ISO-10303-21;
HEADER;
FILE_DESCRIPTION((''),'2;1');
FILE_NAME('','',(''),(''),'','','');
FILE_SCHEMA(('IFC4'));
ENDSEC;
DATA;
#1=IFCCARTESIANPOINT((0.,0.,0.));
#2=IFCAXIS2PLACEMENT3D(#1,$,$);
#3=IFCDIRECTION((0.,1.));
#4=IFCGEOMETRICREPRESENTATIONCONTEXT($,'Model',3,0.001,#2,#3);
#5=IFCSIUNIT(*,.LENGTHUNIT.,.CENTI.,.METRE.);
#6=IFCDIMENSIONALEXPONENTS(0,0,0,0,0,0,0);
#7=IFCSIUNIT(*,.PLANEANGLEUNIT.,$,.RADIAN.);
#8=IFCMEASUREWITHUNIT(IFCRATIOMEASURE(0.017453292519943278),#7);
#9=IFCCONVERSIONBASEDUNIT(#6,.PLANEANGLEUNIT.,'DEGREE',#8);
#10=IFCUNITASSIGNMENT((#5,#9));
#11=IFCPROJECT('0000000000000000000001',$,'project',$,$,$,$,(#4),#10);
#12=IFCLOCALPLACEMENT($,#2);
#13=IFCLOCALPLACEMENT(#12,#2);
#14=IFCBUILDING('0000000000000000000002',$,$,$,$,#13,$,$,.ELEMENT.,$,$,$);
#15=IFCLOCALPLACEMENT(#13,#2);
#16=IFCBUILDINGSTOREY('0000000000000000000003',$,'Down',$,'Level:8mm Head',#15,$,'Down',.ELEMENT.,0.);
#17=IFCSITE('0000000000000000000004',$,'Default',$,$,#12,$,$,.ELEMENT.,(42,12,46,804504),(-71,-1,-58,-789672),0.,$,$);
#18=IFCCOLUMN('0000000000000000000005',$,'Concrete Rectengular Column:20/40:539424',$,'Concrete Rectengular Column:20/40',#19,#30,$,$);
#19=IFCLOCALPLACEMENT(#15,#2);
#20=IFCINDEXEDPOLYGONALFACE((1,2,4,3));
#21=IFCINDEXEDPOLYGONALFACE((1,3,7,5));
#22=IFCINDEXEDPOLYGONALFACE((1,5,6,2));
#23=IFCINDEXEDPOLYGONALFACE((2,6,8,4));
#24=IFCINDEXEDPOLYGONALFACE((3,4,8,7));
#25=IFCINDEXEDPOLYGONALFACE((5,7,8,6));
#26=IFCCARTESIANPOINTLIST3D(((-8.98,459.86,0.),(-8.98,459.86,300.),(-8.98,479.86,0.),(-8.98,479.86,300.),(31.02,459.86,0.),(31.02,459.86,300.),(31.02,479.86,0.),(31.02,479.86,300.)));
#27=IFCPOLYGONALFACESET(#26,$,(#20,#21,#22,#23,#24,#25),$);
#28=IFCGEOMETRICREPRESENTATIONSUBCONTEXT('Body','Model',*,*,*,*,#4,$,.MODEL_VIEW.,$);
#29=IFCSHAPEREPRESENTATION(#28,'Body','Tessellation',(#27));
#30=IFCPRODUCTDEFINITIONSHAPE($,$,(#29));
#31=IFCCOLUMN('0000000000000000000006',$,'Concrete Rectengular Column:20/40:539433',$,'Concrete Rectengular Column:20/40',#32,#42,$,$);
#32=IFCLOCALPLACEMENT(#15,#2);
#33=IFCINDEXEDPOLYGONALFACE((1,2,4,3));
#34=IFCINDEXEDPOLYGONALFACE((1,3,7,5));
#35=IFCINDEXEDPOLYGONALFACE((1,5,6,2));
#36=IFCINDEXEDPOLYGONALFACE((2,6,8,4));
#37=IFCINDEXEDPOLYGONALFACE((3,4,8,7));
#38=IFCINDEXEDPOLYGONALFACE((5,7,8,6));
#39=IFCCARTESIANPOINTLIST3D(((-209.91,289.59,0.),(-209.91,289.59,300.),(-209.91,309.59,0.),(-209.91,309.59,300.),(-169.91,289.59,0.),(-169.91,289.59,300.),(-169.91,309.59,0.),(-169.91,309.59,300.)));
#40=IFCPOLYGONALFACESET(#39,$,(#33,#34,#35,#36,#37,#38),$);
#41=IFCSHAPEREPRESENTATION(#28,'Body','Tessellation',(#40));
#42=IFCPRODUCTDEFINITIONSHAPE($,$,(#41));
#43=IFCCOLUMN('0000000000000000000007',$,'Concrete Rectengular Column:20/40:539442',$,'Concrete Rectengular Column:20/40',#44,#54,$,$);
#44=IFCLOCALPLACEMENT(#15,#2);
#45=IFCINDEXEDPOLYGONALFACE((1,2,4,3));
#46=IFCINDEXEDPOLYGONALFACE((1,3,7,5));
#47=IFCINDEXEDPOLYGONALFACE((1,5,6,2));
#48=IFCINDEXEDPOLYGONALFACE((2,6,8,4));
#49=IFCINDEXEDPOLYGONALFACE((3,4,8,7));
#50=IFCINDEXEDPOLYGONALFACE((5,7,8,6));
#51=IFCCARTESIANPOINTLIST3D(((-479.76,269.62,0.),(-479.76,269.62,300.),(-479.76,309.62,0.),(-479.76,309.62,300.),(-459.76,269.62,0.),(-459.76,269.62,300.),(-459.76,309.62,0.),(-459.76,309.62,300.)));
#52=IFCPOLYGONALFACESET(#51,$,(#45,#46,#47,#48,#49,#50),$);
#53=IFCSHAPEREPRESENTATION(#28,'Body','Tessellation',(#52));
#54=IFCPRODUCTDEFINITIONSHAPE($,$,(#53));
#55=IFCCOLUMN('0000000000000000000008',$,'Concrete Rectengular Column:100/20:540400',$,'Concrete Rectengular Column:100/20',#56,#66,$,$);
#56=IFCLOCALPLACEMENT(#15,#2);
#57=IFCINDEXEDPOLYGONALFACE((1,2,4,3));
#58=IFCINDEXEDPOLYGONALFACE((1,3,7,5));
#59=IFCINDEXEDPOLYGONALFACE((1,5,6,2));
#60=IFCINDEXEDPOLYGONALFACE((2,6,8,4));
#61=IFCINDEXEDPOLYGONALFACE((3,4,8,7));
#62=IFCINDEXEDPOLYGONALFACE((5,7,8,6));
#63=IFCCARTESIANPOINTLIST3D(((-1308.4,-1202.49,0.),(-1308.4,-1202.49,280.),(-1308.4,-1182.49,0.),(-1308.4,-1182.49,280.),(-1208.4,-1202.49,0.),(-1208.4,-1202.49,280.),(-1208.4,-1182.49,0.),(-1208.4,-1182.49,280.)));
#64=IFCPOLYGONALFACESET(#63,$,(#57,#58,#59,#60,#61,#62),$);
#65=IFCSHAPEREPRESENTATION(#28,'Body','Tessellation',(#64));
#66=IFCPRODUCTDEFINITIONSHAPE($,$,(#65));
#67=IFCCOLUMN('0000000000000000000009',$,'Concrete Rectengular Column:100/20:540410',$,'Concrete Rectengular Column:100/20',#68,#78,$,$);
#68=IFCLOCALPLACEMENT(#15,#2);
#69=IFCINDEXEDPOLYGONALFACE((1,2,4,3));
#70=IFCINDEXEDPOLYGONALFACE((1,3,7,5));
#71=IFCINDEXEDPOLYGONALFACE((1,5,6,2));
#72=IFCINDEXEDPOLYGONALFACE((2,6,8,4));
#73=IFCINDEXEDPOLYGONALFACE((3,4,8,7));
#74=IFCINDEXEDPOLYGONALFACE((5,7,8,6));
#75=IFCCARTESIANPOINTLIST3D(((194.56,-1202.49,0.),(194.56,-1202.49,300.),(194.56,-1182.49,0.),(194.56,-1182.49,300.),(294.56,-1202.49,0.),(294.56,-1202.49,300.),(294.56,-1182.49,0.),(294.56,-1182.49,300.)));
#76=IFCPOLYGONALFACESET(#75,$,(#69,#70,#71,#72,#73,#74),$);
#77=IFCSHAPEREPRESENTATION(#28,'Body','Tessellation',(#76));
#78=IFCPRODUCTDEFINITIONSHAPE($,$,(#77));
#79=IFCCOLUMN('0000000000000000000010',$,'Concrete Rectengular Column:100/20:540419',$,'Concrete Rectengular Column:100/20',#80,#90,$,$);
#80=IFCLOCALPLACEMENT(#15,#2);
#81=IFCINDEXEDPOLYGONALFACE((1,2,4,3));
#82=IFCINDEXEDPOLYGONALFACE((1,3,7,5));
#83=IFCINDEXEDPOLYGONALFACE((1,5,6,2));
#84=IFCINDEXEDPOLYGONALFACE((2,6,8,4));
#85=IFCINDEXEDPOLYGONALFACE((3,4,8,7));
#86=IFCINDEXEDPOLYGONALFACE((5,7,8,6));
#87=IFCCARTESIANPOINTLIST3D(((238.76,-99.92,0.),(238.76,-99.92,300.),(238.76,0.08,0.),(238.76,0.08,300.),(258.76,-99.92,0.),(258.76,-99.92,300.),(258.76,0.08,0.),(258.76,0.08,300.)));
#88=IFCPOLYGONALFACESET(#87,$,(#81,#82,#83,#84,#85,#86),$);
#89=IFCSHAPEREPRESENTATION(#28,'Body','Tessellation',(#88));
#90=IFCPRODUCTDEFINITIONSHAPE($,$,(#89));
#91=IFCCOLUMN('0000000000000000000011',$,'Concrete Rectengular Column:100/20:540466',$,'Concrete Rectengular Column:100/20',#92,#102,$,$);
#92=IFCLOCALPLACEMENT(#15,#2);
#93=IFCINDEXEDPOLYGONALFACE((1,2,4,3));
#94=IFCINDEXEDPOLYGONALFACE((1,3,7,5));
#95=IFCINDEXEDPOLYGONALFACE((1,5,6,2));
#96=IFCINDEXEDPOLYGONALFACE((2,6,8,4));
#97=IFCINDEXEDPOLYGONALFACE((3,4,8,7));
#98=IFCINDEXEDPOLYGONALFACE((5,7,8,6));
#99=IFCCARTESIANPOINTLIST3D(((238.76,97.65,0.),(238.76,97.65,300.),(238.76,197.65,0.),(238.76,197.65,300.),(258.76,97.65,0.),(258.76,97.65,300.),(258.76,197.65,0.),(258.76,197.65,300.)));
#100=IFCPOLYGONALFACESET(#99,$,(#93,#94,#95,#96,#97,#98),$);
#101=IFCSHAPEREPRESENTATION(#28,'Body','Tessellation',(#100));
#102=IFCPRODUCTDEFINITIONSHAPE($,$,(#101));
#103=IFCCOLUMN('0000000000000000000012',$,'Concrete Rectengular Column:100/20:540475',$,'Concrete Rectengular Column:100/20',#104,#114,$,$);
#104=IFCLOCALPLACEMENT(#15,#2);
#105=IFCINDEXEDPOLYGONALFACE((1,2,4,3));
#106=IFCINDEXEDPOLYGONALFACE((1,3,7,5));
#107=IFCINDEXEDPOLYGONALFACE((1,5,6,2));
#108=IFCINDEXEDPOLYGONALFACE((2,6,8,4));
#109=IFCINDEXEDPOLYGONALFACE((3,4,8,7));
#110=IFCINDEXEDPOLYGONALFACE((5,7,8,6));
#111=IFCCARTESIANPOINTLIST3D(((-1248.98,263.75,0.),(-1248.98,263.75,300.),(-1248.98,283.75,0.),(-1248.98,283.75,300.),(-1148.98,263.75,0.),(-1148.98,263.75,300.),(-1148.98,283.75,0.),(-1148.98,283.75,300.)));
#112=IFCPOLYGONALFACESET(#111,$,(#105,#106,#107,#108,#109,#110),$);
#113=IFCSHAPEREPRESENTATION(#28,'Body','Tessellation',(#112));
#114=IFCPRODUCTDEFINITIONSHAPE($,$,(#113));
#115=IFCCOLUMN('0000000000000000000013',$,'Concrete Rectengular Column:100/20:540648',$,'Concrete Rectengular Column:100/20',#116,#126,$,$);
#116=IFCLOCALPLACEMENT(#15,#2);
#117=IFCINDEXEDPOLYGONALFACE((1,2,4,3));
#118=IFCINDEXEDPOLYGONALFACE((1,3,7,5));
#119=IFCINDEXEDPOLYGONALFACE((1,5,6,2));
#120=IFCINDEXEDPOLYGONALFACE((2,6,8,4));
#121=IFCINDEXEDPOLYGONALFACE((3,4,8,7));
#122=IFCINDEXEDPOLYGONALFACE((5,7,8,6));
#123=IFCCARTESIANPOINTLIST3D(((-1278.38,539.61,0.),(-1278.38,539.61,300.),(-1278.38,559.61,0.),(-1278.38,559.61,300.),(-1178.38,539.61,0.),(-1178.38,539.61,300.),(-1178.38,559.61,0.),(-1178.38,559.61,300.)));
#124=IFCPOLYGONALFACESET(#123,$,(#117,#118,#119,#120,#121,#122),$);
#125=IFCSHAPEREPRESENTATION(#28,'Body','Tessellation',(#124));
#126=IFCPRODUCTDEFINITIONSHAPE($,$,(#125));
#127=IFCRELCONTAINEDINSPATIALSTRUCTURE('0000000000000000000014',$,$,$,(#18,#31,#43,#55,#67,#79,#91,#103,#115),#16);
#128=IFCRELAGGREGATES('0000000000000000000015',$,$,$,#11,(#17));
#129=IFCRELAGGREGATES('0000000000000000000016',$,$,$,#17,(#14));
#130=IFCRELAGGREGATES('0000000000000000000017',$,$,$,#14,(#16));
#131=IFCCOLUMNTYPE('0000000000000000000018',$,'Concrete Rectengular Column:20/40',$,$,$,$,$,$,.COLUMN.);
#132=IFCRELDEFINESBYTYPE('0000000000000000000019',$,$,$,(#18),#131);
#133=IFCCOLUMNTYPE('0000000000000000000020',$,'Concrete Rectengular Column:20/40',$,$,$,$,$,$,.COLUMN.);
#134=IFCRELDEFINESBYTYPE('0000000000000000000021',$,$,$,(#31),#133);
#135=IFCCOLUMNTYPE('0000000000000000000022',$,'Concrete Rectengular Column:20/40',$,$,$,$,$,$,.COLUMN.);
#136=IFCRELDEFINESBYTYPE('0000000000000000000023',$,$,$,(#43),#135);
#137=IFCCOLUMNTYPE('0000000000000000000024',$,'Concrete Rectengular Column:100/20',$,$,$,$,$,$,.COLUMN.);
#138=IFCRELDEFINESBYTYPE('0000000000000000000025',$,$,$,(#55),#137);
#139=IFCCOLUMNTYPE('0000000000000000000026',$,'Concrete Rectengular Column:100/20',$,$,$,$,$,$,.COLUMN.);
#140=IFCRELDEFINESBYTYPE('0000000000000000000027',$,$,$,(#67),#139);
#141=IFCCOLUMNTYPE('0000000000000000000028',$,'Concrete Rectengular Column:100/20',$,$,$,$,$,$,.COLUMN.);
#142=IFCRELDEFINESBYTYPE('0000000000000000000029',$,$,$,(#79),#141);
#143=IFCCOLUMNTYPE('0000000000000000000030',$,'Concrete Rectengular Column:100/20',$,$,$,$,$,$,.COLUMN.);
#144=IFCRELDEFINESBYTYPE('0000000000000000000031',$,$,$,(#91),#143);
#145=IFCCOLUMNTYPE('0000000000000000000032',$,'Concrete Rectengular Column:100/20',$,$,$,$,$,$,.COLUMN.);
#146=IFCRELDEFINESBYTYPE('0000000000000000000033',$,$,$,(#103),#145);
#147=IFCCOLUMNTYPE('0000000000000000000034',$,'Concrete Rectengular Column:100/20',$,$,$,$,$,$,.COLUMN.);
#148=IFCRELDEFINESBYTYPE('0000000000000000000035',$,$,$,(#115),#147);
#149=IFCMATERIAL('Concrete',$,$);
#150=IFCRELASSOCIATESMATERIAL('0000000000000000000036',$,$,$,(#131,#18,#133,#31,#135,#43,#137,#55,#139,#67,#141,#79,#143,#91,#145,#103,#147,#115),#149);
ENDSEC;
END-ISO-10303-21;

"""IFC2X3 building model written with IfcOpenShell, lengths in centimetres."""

from ifc_helpers import new_model, entity, si_unit, converted_unit, direction, frame, frame_2d, origin, origin_2d_with_axis, place, context, subcontext, project, spatial, rectangle, extrude, source, transform, mapped, material, type_object, type_shapes, element, save


model = new_model("IFC2X3")

# Units and contexts
model_context = context("Model", 3, precision=0.001, world=origin(), true_north=direction((0.0, 1.0)))
body_context = subcontext(model_context, "Body", "Model", "MODEL_VIEW")
ifc_project = project(units=[si_unit("LENGTHUNIT", "METRE", prefix="CENTI"), converted_unit("PLANEANGLEUNIT", "DEGREE", entity("IfcRatioMeasure", 0.017453292519943278), si_unit("PLANEANGLEUNIT", "RADIAN"), dimensions=[0, 0, 0, 0, 0, 0, 0])], contexts=[model_context])

# Site, building, storey
site_placement = place(None, origin())
site = spatial("IfcSite", under=ifc_project, at=site_placement, Name="Default", CompositionType="ELEMENT", RefLatitude=(42, 12, 46, 804504), RefLongitude=(-71, -1, -58, -789672), RefElevation=0.0)
building_placement = place(site_placement, origin())
building = spatial("IfcBuilding", under=site, at=building_placement, CompositionType="ELEMENT")
storey_placement = place(building_placement, origin())
storey = spatial("IfcBuildingStorey", under=building, at=storey_placement, Name="Down", ObjectType="Level:8mm Head", LongName="Down", CompositionType="ELEMENT", Elevation=0.0)

# Columns
ifc_material = material(Name="Concrete")
column_type_1 = type_object("IfcColumnType", Name="Concrete Rectengular Column:20/40", PredefinedType="COLUMN", material=ifc_material)
shared_shape_1 = source(origin(), body_context, "Body", "SweptSolid", [
    extrude(rectangle(XDim=20.0, YDim=40.0, at=origin_2d_with_axis()), frame((11.02, 469.86, 0.0), z_axis=(0.0, 0.0, 1.0), x_axis=(0.0, -1.0, 0.0)), (0.0, 0.0, 1.0), 300.0),
])
type_shapes(column_type_1, [shared_shape_1])
column_1_placement = place(storey_placement, origin())
element("IfcColumn", 1, at=column_1_placement, inside=storey, type_object=column_type_1, material=ifc_material, Name="Concrete Rectengular Column:20/40:539424", ObjectType="Concrete Rectengular Column:20/40", context=body_context, shape_type="MappedRepresentation", body=[
    mapped(shared_shape_1, transform((0.0, 0.0, 0.0), scale=1.0)),
])
column_type_2 = type_object("IfcColumnType", Name="Concrete Rectengular Column:20/40", PredefinedType="COLUMN", material=ifc_material)
shared_shape_2 = source(origin(), body_context, "Body", "SweptSolid", [
    extrude(rectangle(XDim=20.0, YDim=40.0, at=origin_2d_with_axis()), frame((-189.91, 299.59, 0.0), z_axis=(0.0, 0.0, 1.0), x_axis=(0.0, -1.0, 0.0)), (0.0, 0.0, 1.0), 300.0),
])
type_shapes(column_type_2, [shared_shape_2])
column_2_placement = place(storey_placement, origin())
element("IfcColumn", 2, at=column_2_placement, inside=storey, type_object=column_type_2, material=ifc_material, Name="Concrete Rectengular Column:20/40:539433", ObjectType="Concrete Rectengular Column:20/40", context=body_context, shape_type="MappedRepresentation", body=[
    mapped(shared_shape_2, transform((0.0, 0.0, 0.0), scale=1.0)),
])
column_type_3 = type_object("IfcColumnType", Name="Concrete Rectengular Column:20/40", PredefinedType="COLUMN", material=ifc_material)
shared_shape_3 = source(origin(), body_context, "Body", "SweptSolid", [
    extrude(rectangle(XDim=40.0, YDim=20.0, at=origin_2d_with_axis()), frame((-469.76, 289.62, 0.0), z_axis=(0.0, 0.0, 1.0), x_axis=(0.0, -1.0, 0.0)), (0.0, 0.0, 1.0), 300.0),
])
type_shapes(column_type_3, [shared_shape_3])
column_3_placement = place(storey_placement, origin())
element("IfcColumn", 3, at=column_3_placement, inside=storey, type_object=column_type_3, material=ifc_material, Name="Concrete Rectengular Column:20/40:539442", ObjectType="Concrete Rectengular Column:20/40", context=body_context, shape_type="MappedRepresentation", body=[
    mapped(shared_shape_3, transform((0.0, 0.0, 0.0), scale=1.0)),
])
column_type_4 = type_object("IfcColumnType", Name="Concrete Rectengular Column:100/20", PredefinedType="COLUMN", material=ifc_material)
shared_shape_4 = source(origin(), body_context, "Body", "SweptSolid", [
    extrude(rectangle(XDim=20.0, YDim=100.0, at=frame_2d((0.0, 0.0), x_axis=(1.0, 0.0))), frame((-1258.4, -1192.49, 0.0), z_axis=(0.0, 0.0, 1.0), x_axis=(0.0, -1.0, 0.0)), (0.0, 0.0, 1.0), 280.0),
])
type_shapes(column_type_4, [shared_shape_4])
column_4_placement = place(storey_placement, origin())
element("IfcColumn", 4, at=column_4_placement, inside=storey, type_object=column_type_4, material=ifc_material, Name="Concrete Rectengular Column:100/20:540400", ObjectType="Concrete Rectengular Column:100/20", context=body_context, shape_type="MappedRepresentation", body=[
    mapped(shared_shape_4, transform((0.0, 0.0, 0.0), scale=1.0)),
])
column_type_5 = type_object("IfcColumnType", Name="Concrete Rectengular Column:100/20", PredefinedType="COLUMN", material=ifc_material)
shared_shape_5 = source(origin(), body_context, "Body", "SweptSolid", [
    extrude(rectangle(XDim=20.0, YDim=100.0, at=frame_2d((0.0, 0.0), x_axis=(1.0, 0.0))), frame((244.56, -1192.49, 0.0), z_axis=(0.0, 0.0, 1.0), x_axis=(0.0, -1.0, 0.0)), (0.0, 0.0, 1.0), 300.0),
])
type_shapes(column_type_5, [shared_shape_5])
column_5_placement = place(storey_placement, origin())
element("IfcColumn", 5, at=column_5_placement, inside=storey, type_object=column_type_5, material=ifc_material, Name="Concrete Rectengular Column:100/20:540410", ObjectType="Concrete Rectengular Column:100/20", context=body_context, shape_type="MappedRepresentation", body=[
    mapped(shared_shape_5, transform((0.0, 0.0, 0.0), scale=1.0)),
])
column_type_6 = type_object("IfcColumnType", Name="Concrete Rectengular Column:100/20", PredefinedType="COLUMN", material=ifc_material)
shared_shape_6 = source(origin(), body_context, "Body", "SweptSolid", [
    extrude(rectangle(XDim=100.0, YDim=20.0, at=frame_2d((0.0, 0.0), x_axis=(1.0, 0.0))), frame((248.76, -49.92, 0.0), z_axis=(0.0, 0.0, 1.0), x_axis=(0.0, -1.0, 0.0)), (0.0, 0.0, 1.0), 300.0),
])
type_shapes(column_type_6, [shared_shape_6])
column_6_placement = place(storey_placement, origin())
element("IfcColumn", 6, at=column_6_placement, inside=storey, type_object=column_type_6, material=ifc_material, Name="Concrete Rectengular Column:100/20:540419", ObjectType="Concrete Rectengular Column:100/20", context=body_context, shape_type="MappedRepresentation", body=[
    mapped(shared_shape_6, transform((0.0, 0.0, 0.0), scale=1.0)),
])
column_type_7 = type_object("IfcColumnType", Name="Concrete Rectengular Column:100/20", PredefinedType="COLUMN", material=ifc_material)
shared_shape_7 = source(origin(), body_context, "Body", "SweptSolid", [
    extrude(rectangle(XDim=100.0, YDim=20.0, at=frame_2d((0.0, 0.0), x_axis=(1.0, 0.0))), frame((248.76, 147.65, 0.0), z_axis=(0.0, 0.0, 1.0), x_axis=(0.0, -1.0, 0.0)), (0.0, 0.0, 1.0), 300.0),
])
type_shapes(column_type_7, [shared_shape_7])
column_7_placement = place(storey_placement, origin())
element("IfcColumn", 7, at=column_7_placement, inside=storey, type_object=column_type_7, material=ifc_material, Name="Concrete Rectengular Column:100/20:540466", ObjectType="Concrete Rectengular Column:100/20", context=body_context, shape_type="MappedRepresentation", body=[
    mapped(shared_shape_7, transform((0.0, 0.0, 0.0), scale=1.0)),
])
column_type_8 = type_object("IfcColumnType", Name="Concrete Rectengular Column:100/20", PredefinedType="COLUMN", material=ifc_material)
shared_shape_8 = source(origin(), body_context, "Body", "SweptSolid", [
    extrude(rectangle(XDim=20.0, YDim=100.0, at=frame_2d((0.0, 0.0), x_axis=(1.0, 0.0))), frame((-1198.98, 273.75, 0.0), z_axis=(0.0, 0.0, 1.0), x_axis=(0.0, -1.0, 0.0)), (0.0, 0.0, 1.0), 300.0),
])
type_shapes(column_type_8, [shared_shape_8])
column_8_placement = place(storey_placement, origin())
element("IfcColumn", 8, at=column_8_placement, inside=storey, type_object=column_type_8, material=ifc_material, Name="Concrete Rectengular Column:100/20:540475", ObjectType="Concrete Rectengular Column:100/20", context=body_context, shape_type="MappedRepresentation", body=[
    mapped(shared_shape_8, transform((0.0, 0.0, 0.0), scale=1.0)),
])
column_type_9 = type_object("IfcColumnType", Name="Concrete Rectengular Column:100/20", PredefinedType="COLUMN", material=ifc_material)
shared_shape_9 = source(origin(), body_context, "Body", "SweptSolid", [
    extrude(rectangle(XDim=20.0, YDim=100.0, at=frame_2d((0.0, 0.0), x_axis=(1.0, 0.0))), frame((-1228.38, 549.61, 0.0), z_axis=(0.0, 0.0, 1.0), x_axis=(0.0, -1.0, 0.0)), (0.0, 0.0, 1.0), 300.0),
])
type_shapes(column_type_9, [shared_shape_9])
column_9_placement = place(storey_placement, origin())
element("IfcColumn", 9, at=column_9_placement, inside=storey, type_object=column_type_9, material=ifc_material, Name="Concrete Rectengular Column:100/20:540648", ObjectType="Concrete Rectengular Column:100/20", context=body_context, shape_type="MappedRepresentation", body=[
    mapped(shared_shape_9, transform((0.0, 0.0, 0.0), scale=1.0)),
])

save(model, "model.ifc")
